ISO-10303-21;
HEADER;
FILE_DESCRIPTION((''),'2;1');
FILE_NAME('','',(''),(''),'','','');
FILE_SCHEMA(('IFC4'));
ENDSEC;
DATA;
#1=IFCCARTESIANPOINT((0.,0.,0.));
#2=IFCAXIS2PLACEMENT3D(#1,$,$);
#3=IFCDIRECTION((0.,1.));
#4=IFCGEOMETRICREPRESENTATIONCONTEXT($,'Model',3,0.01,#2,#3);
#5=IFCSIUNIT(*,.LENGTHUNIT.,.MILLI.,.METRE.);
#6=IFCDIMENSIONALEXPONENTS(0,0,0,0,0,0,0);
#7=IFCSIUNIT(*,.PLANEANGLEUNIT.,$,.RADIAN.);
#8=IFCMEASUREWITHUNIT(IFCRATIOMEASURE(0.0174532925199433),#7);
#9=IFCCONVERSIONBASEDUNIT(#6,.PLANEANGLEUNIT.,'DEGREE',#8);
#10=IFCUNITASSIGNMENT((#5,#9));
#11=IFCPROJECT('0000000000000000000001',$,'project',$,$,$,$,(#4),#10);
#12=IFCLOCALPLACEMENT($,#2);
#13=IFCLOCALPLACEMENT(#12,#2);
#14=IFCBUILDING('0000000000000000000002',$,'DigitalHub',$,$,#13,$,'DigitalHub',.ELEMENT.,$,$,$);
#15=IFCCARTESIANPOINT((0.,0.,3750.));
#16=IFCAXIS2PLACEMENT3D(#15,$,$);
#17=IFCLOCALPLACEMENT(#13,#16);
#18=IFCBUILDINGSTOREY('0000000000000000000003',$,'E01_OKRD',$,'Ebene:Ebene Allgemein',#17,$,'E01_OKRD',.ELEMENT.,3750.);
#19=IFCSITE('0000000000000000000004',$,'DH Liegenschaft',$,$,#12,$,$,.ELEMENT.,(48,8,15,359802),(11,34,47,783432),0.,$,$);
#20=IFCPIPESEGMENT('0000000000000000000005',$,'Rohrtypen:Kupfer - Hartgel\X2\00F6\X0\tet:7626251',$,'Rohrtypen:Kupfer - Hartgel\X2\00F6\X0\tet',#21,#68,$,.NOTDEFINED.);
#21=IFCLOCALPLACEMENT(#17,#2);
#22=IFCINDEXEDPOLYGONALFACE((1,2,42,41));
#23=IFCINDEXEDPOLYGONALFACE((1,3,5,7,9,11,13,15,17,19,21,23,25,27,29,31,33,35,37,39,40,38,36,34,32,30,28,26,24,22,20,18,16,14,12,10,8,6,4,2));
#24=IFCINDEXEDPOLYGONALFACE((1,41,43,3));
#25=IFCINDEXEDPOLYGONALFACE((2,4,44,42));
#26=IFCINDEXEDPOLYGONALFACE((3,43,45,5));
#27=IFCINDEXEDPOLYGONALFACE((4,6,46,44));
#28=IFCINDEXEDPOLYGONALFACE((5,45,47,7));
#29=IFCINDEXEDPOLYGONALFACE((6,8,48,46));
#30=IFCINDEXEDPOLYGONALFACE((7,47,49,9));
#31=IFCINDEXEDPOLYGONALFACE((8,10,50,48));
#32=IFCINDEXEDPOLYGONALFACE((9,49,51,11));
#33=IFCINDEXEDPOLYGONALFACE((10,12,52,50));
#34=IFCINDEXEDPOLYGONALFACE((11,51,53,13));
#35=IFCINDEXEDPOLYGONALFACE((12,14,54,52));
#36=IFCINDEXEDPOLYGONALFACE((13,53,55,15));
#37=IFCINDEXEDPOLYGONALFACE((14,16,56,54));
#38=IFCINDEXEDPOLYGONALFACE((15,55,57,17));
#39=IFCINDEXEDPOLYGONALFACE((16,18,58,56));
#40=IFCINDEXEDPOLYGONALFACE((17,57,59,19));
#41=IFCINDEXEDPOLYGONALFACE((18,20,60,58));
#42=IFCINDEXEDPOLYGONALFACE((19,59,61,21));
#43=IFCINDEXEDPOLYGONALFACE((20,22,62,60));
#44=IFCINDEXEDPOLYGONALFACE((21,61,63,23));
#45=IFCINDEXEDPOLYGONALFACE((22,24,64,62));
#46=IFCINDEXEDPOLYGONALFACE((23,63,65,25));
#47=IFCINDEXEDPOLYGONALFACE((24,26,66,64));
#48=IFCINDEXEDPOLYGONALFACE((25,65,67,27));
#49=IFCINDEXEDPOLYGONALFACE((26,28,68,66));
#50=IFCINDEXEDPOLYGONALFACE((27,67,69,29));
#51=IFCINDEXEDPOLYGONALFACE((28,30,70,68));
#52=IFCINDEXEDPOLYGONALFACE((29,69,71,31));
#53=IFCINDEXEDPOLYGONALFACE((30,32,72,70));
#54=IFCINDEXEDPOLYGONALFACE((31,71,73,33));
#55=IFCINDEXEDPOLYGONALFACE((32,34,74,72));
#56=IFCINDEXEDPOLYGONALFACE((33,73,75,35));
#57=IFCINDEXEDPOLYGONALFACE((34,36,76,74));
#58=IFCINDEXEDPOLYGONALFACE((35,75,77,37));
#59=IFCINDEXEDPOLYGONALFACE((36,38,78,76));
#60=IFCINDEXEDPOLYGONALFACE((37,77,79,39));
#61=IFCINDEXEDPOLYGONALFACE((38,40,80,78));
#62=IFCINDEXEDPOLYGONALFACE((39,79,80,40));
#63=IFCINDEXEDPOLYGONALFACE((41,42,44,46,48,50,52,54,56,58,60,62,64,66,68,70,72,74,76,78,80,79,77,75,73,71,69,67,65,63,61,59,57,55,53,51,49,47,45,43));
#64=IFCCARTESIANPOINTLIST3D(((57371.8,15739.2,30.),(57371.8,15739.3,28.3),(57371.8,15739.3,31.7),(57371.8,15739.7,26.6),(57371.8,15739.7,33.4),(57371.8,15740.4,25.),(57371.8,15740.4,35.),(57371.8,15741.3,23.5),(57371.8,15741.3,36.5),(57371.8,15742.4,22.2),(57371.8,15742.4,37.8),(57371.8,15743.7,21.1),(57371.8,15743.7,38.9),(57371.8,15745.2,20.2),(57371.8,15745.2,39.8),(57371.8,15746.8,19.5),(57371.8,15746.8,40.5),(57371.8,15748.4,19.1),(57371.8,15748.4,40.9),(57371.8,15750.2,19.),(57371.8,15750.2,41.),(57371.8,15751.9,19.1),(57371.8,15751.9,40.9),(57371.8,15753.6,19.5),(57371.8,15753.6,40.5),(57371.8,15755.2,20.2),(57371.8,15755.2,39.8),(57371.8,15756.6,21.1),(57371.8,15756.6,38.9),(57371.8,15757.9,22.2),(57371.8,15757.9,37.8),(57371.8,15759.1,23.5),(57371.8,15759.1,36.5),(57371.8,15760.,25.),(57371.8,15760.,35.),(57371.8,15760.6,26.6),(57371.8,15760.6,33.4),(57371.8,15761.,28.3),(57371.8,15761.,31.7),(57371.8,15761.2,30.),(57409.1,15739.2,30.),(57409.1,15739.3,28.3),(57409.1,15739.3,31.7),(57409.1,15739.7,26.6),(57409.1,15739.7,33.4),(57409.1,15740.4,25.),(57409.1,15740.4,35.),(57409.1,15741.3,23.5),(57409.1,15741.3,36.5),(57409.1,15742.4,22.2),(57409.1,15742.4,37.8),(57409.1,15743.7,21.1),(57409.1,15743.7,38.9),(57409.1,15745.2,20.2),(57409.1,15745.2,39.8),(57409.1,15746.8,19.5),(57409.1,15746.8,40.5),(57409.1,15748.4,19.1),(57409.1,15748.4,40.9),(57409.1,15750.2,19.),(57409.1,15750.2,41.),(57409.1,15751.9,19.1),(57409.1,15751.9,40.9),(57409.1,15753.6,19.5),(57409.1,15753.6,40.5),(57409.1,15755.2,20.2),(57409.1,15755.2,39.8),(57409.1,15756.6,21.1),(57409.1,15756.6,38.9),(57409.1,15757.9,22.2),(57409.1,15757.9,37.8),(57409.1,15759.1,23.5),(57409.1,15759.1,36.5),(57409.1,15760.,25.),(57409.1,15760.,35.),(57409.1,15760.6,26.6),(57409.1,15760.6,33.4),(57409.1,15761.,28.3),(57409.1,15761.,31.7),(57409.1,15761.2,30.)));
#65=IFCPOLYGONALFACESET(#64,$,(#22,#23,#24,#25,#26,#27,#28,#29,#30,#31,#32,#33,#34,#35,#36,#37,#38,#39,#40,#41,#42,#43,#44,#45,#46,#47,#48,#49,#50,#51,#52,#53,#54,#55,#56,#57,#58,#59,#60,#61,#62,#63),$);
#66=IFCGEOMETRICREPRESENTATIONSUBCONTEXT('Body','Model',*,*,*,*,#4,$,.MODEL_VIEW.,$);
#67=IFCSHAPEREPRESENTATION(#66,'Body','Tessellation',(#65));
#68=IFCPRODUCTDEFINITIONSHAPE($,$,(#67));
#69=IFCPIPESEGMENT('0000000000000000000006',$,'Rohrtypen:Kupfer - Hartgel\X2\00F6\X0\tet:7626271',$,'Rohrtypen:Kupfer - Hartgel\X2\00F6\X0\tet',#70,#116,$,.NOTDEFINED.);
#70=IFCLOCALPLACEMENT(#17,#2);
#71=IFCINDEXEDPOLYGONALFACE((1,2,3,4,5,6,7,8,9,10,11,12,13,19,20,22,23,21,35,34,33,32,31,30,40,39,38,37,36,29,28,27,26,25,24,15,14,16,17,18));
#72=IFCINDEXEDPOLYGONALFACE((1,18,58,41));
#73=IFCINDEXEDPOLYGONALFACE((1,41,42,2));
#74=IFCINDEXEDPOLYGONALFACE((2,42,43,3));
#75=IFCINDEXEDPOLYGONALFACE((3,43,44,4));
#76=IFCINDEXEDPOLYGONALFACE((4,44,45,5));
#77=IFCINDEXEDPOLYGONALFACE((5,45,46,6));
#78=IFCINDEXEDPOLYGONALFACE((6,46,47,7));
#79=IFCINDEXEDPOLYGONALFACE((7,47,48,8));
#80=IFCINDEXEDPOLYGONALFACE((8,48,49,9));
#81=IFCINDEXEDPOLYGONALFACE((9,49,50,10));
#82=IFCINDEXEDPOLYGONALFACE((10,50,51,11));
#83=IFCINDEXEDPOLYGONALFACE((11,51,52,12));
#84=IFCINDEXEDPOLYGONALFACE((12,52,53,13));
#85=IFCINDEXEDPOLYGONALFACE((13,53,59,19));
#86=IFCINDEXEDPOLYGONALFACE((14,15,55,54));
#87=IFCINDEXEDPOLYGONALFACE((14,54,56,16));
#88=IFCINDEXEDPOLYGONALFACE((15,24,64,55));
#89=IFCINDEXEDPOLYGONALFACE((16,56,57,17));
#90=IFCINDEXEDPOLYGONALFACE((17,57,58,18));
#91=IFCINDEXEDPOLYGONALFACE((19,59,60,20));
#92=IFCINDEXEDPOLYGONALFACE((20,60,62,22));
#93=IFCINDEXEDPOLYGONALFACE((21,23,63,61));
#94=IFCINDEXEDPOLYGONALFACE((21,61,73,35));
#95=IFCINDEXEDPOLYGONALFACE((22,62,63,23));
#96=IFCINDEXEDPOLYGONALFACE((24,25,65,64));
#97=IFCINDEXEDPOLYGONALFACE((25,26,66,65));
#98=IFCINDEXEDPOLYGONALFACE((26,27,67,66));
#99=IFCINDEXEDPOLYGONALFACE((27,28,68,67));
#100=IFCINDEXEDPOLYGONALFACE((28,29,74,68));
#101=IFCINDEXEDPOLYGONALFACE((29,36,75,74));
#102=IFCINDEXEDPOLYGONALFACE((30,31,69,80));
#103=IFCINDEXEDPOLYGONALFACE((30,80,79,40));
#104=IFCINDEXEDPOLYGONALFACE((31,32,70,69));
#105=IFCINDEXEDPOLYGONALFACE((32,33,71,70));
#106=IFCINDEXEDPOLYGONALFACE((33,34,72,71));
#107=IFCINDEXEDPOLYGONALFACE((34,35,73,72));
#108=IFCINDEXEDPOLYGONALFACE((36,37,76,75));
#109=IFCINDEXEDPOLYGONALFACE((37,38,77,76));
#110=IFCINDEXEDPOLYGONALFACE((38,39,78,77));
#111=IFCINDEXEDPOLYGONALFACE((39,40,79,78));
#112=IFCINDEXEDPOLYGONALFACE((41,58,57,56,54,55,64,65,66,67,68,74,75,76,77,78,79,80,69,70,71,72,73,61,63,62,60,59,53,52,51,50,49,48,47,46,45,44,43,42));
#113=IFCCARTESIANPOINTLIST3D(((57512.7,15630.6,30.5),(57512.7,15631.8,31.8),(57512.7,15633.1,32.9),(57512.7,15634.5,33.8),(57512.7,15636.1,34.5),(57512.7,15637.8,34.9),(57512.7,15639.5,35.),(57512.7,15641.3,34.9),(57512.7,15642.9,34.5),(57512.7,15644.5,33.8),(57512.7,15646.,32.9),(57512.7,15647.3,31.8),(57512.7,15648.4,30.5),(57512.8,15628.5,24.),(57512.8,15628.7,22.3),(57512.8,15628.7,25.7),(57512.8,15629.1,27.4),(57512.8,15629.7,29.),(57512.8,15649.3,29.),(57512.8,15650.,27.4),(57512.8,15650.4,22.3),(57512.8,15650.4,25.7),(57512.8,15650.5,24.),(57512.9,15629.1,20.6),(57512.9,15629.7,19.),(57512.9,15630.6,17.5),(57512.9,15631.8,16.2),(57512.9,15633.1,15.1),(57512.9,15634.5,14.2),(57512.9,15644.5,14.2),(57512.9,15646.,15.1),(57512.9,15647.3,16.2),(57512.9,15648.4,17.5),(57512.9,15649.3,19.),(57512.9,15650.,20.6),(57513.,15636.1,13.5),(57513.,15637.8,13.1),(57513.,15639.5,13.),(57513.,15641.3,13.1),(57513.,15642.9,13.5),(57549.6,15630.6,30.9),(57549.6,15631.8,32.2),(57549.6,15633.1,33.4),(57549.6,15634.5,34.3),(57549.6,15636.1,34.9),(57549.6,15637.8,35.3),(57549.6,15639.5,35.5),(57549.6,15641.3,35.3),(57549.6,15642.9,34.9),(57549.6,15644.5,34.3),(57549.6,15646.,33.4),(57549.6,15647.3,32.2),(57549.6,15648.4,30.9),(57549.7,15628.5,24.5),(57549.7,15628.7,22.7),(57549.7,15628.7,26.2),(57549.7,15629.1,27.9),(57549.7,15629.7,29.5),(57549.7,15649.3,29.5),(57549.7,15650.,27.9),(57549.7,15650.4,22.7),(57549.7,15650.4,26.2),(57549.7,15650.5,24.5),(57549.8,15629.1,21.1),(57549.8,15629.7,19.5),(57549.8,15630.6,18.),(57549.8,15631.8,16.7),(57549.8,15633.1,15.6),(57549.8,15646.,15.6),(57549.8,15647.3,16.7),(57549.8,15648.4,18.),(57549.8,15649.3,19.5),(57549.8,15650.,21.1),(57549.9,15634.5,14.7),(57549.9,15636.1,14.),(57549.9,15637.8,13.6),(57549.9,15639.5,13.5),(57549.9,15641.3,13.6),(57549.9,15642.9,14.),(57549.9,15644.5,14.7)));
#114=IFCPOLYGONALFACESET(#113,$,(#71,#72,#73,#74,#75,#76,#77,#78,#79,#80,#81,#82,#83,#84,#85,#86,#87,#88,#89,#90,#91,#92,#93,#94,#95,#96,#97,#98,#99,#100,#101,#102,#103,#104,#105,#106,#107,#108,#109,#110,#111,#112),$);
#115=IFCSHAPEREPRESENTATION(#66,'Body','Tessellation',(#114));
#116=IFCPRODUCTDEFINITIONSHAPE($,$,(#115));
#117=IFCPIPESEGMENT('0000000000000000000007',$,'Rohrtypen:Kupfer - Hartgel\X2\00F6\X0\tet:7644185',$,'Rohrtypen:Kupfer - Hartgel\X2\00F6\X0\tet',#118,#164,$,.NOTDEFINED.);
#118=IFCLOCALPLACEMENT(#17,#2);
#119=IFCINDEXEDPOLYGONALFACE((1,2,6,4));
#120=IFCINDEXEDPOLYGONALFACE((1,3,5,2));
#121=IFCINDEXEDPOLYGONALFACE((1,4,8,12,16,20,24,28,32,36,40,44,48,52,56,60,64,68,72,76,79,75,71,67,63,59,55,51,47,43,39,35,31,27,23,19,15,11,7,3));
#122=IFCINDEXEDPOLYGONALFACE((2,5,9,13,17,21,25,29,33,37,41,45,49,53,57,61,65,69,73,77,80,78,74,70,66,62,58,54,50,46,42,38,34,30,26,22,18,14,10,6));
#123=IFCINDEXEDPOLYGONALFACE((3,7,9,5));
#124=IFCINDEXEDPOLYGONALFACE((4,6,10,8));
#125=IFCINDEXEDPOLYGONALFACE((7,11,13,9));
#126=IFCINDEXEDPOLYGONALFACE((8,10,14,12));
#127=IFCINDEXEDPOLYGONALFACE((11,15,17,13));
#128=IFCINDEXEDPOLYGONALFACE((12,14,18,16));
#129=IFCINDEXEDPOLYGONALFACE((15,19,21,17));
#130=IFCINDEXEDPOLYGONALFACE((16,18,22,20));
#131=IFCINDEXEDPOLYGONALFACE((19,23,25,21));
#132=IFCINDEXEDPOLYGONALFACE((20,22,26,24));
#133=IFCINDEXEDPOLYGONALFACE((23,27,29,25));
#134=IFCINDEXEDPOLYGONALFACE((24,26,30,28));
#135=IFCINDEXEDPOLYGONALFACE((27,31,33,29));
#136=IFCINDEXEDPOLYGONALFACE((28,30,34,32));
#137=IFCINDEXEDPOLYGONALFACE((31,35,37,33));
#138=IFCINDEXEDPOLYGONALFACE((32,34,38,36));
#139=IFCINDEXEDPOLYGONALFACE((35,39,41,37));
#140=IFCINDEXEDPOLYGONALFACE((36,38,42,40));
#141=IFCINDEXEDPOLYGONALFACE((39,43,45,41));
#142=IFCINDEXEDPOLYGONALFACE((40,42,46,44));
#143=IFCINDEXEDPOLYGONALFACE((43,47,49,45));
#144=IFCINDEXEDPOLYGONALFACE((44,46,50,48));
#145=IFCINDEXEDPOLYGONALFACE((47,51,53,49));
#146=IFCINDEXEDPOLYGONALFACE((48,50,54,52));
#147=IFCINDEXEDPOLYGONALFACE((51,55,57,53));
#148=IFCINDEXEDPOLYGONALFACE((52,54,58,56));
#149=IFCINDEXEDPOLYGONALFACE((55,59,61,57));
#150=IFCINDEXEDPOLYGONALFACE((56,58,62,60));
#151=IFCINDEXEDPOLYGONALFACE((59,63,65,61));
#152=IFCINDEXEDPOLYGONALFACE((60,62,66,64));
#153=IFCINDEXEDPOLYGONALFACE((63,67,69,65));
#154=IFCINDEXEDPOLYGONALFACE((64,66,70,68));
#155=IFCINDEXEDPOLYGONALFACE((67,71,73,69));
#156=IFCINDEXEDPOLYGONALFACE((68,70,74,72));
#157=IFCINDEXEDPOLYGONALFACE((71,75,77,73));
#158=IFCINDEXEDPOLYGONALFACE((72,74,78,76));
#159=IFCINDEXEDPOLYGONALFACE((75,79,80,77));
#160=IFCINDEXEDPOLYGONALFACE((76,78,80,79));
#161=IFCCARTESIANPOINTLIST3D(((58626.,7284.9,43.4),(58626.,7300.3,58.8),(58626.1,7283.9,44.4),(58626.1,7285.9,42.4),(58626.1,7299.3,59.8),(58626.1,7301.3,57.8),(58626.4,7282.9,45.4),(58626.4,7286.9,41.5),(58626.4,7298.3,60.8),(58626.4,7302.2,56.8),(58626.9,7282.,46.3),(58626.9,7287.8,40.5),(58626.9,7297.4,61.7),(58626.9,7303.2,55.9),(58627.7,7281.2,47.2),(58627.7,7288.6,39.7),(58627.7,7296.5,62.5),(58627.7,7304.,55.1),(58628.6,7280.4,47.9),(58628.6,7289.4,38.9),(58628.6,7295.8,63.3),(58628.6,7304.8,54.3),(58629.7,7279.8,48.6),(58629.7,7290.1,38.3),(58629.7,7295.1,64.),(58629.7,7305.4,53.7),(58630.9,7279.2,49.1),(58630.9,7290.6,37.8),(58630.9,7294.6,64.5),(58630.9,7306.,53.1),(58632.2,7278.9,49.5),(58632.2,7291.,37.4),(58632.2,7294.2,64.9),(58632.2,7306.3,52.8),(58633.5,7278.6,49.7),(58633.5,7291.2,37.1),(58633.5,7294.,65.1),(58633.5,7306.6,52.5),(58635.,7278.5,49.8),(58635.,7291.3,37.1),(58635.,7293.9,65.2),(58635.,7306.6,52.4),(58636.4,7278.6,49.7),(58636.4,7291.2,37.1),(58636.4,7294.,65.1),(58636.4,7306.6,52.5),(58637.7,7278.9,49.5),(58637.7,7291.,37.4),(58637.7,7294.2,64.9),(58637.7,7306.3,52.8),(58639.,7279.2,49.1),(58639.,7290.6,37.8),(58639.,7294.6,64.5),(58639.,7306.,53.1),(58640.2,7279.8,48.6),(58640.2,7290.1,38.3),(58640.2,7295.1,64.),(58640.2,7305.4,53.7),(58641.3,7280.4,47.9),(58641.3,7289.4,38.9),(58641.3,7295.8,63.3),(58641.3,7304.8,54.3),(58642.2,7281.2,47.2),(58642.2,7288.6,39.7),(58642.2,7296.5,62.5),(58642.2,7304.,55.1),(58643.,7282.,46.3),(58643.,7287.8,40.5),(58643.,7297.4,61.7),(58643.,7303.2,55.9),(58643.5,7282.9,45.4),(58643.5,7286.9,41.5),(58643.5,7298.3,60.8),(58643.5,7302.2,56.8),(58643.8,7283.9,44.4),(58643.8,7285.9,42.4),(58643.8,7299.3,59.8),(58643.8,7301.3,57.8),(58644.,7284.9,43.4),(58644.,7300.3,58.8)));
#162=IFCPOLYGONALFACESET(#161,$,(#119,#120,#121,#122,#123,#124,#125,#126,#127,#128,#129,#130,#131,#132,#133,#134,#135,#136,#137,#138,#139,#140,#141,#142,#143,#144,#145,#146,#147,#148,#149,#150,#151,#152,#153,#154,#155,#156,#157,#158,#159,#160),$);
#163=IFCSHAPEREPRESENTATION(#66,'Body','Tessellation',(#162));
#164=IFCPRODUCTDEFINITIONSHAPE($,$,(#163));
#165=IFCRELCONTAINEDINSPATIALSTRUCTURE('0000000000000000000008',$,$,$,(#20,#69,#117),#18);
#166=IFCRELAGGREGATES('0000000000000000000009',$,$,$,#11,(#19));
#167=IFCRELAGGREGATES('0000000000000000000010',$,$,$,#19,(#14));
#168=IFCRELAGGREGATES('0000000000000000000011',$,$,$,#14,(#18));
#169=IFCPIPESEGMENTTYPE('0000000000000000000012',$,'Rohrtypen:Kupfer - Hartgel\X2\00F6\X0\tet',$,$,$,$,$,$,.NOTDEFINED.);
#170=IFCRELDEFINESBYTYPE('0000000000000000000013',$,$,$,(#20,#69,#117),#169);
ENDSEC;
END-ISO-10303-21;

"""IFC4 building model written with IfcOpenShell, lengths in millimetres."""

from ifc_helpers import new_model, entity, si_unit, converted_unit, direction, frame, origin, place, context, subcontext, project, spatial, indexed_curve, outline, extrude, type_object, element, save


model = new_model("IFC4")

# Units and contexts
model_context = context("Model", 3, precision=0.01, world=origin(), true_north=direction((0.0, 1.0)))
body_context = subcontext(model_context, "Body", "Model", "MODEL_VIEW")
ifc_project = project(units=[si_unit("LENGTHUNIT", "METRE", prefix="MILLI"), converted_unit("PLANEANGLEUNIT", "DEGREE", entity("IfcRatioMeasure", 0.0174532925199433), si_unit("PLANEANGLEUNIT", "RADIAN"), dimensions=[0, 0, 0, 0, 0, 0, 0])], contexts=[model_context])

# Site, building, storey
site_placement = place(None, origin())
site = spatial("IfcSite", under=ifc_project, at=site_placement, Name="DH Liegenschaft", CompositionType="ELEMENT", RefLatitude=(48, 8, 15, 359802), RefLongitude=(11, 34, 47, 783432), RefElevation=0.0)
building_placement = place(site_placement, origin())
building = spatial("IfcBuilding", under=site, at=building_placement, Name="DigitalHub", LongName="DigitalHub", CompositionType="ELEMENT")
storey_placement = place(building_placement, frame((0.0, 0.0, 3750.0)))
storey = spatial("IfcBuildingStorey", under=building, at=storey_placement, Name="E01_OKRD", ObjectType="Ebene:Ebene Allgemein", LongName="E01_OKRD", CompositionType="ELEMENT", Elevation=3750.0)

# Pipe segments
pipe_segment_type = type_object("IfcPipeSegmentType", Name="Rohrtypen:Kupfer - Hartgelötet", PredefinedType="NOTDEFINED")
pipe_segment_1_placement = place(storey_placement, frame((57371.8, 15737.6, 17.4)))
element("IfcPipeSegment", 1, at=pipe_segment_1_placement, inside=storey, type_object=pipe_segment_type, Name="Rohrtypen:Kupfer - Hartgelötet:7626251", ObjectType="Rohrtypen:Kupfer - Hartgelötet", PredefinedType="NOTDEFINED", context=body_context, shape_type="SweptSolid", body=[
    extrude(outline(indexed_curve([(11.0, 0.0), (10.9, 1.7), (10.5, 3.4), (9.8, 5.0), (8.9, 6.5), (7.8, 7.8), (6.5, 8.9), (5.0, 9.8), (3.4, 10.5), (1.7, 10.9), (0.0, 11.0), (-1.7, 10.9), (-3.4, 10.5), (-5.0, 9.8), (-6.5, 8.9), (-7.8, 7.8), (-8.9, 6.5), (-9.8, 5.0), (-10.5, 3.4), (-10.9, 1.7), (-11.0, 0.0), (-10.9, -1.7), (-10.5, -3.4), (-9.8, -5.0), (-8.9, -6.5), (-7.8, -7.8), (-6.5, -8.9), (-5.0, -9.8), (-3.4, -10.5), (-1.7, -10.9), (0.0, -11.0), (1.7, -10.9), (3.4, -10.5), (5.0, -9.8), (6.5, -8.9), (7.8, -7.8), (8.9, -6.5), (9.8, -5.0), (10.5, -3.4), (10.9, -1.7), (11.0, 0.0)], self_intersect=False)), frame((0.0, 12.6, 12.6), z_axis=(1.0, 0.0, 0.0), x_axis=(0.0, 1.0, 0.0)), (0.0, 0.0, 1.0), 37.2),
])
pipe_segment_2_placement = place(storey_placement, frame((57512.7, 15626.9, 11.4)))
element("IfcPipeSegment", 2, at=pipe_segment_2_placement, inside=storey, type_object=pipe_segment_type, Name="Rohrtypen:Kupfer - Hartgelötet:7626271", ObjectType="Rohrtypen:Kupfer - Hartgelötet", PredefinedType="NOTDEFINED", context=body_context, shape_type="SweptSolid", body=[
    extrude(outline(indexed_curve([(11.0, 0.0), (10.9, 1.7), (10.5, 3.4), (9.8, 5.0), (8.9, 6.5), (7.8, 7.8), (6.5, 8.9), (5.0, 9.8), (3.4, 10.5), (1.7, 10.9), (0.0, 11.0), (-1.7, 10.9), (-3.4, 10.5), (-5.0, 9.8), (-6.5, 8.9), (-7.8, 7.8), (-8.9, 6.5), (-9.8, 5.0), (-10.5, 3.4), (-10.9, 1.7), (-11.0, 0.0), (-10.9, -1.7), (-10.5, -3.4), (-9.8, -5.0), (-8.9, -6.5), (-7.8, -7.8), (-6.5, -8.9), (-5.0, -9.8), (-3.4, -10.5), (-1.7, -10.9), (0.0, -11.0), (1.7, -10.9), (3.4, -10.5), (5.0, -9.8), (6.5, -8.9), (7.8, -7.8), (8.9, -6.5), (9.8, -5.0), (10.5, -3.4), (10.9, -1.7), (11.0, 0.0)], self_intersect=False)), frame((0.1, 12.6, 12.6), z_axis=(0.999919, 0.0, 0.012706), x_axis=(0.0, -1.0, 0.0)), (0.0, 0.0, 1.0), 36.9),
])
pipe_segment_3_placement = place(storey_placement, frame((58624.4, 7276.9, 35.5)))
element("IfcPipeSegment", 3, at=pipe_segment_3_placement, inside=storey, type_object=pipe_segment_type, Name="Rohrtypen:Kupfer - Hartgelötet:7644185", ObjectType="Rohrtypen:Kupfer - Hartgelötet", PredefinedType="NOTDEFINED", context=body_context, shape_type="SweptSolid", body=[
    extrude(outline(indexed_curve([(9.0, 0.0), (8.9, 1.4), (8.6, 2.8), (8.0, 4.1), (7.3, 5.3), (6.4, 6.4), (5.3, 7.3), (4.1, 8.0), (2.8, 8.6), (1.4, 8.9), (0.0, 9.0), (-1.4, 8.9), (-2.8, 8.6), (-4.1, 8.0), (-5.3, 7.3), (-6.4, 6.4), (-7.3, 5.3), (-8.0, 4.1), (-8.6, 2.8), (-8.9, 1.4), (-9.0, 0.0), (-8.9, -1.4), (-8.6, -2.8), (-8.0, -4.1), (-7.3, -5.3), (-6.4, -6.4), (-5.3, -7.3), (-4.1, -8.0), (-2.8, -8.6), (-1.4, -8.9), (0.0, -9.0), (1.4, -8.9), (2.8, -8.6), (4.1, -8.0), (5.3, -7.3), (6.4, -6.4), (7.3, -5.3), (8.0, -4.1), (8.6, -2.8), (8.9, -1.4), (9.0, 0.0)], self_intersect=False)), frame((10.6, 8.0, 8.0), z_axis=(0.0, 0.707107, 0.707107), x_axis=(1.0, 0.0, 0.0)), (0.0, 0.0, 1.0), 21.7),
])

save(model, "model.ifc")
